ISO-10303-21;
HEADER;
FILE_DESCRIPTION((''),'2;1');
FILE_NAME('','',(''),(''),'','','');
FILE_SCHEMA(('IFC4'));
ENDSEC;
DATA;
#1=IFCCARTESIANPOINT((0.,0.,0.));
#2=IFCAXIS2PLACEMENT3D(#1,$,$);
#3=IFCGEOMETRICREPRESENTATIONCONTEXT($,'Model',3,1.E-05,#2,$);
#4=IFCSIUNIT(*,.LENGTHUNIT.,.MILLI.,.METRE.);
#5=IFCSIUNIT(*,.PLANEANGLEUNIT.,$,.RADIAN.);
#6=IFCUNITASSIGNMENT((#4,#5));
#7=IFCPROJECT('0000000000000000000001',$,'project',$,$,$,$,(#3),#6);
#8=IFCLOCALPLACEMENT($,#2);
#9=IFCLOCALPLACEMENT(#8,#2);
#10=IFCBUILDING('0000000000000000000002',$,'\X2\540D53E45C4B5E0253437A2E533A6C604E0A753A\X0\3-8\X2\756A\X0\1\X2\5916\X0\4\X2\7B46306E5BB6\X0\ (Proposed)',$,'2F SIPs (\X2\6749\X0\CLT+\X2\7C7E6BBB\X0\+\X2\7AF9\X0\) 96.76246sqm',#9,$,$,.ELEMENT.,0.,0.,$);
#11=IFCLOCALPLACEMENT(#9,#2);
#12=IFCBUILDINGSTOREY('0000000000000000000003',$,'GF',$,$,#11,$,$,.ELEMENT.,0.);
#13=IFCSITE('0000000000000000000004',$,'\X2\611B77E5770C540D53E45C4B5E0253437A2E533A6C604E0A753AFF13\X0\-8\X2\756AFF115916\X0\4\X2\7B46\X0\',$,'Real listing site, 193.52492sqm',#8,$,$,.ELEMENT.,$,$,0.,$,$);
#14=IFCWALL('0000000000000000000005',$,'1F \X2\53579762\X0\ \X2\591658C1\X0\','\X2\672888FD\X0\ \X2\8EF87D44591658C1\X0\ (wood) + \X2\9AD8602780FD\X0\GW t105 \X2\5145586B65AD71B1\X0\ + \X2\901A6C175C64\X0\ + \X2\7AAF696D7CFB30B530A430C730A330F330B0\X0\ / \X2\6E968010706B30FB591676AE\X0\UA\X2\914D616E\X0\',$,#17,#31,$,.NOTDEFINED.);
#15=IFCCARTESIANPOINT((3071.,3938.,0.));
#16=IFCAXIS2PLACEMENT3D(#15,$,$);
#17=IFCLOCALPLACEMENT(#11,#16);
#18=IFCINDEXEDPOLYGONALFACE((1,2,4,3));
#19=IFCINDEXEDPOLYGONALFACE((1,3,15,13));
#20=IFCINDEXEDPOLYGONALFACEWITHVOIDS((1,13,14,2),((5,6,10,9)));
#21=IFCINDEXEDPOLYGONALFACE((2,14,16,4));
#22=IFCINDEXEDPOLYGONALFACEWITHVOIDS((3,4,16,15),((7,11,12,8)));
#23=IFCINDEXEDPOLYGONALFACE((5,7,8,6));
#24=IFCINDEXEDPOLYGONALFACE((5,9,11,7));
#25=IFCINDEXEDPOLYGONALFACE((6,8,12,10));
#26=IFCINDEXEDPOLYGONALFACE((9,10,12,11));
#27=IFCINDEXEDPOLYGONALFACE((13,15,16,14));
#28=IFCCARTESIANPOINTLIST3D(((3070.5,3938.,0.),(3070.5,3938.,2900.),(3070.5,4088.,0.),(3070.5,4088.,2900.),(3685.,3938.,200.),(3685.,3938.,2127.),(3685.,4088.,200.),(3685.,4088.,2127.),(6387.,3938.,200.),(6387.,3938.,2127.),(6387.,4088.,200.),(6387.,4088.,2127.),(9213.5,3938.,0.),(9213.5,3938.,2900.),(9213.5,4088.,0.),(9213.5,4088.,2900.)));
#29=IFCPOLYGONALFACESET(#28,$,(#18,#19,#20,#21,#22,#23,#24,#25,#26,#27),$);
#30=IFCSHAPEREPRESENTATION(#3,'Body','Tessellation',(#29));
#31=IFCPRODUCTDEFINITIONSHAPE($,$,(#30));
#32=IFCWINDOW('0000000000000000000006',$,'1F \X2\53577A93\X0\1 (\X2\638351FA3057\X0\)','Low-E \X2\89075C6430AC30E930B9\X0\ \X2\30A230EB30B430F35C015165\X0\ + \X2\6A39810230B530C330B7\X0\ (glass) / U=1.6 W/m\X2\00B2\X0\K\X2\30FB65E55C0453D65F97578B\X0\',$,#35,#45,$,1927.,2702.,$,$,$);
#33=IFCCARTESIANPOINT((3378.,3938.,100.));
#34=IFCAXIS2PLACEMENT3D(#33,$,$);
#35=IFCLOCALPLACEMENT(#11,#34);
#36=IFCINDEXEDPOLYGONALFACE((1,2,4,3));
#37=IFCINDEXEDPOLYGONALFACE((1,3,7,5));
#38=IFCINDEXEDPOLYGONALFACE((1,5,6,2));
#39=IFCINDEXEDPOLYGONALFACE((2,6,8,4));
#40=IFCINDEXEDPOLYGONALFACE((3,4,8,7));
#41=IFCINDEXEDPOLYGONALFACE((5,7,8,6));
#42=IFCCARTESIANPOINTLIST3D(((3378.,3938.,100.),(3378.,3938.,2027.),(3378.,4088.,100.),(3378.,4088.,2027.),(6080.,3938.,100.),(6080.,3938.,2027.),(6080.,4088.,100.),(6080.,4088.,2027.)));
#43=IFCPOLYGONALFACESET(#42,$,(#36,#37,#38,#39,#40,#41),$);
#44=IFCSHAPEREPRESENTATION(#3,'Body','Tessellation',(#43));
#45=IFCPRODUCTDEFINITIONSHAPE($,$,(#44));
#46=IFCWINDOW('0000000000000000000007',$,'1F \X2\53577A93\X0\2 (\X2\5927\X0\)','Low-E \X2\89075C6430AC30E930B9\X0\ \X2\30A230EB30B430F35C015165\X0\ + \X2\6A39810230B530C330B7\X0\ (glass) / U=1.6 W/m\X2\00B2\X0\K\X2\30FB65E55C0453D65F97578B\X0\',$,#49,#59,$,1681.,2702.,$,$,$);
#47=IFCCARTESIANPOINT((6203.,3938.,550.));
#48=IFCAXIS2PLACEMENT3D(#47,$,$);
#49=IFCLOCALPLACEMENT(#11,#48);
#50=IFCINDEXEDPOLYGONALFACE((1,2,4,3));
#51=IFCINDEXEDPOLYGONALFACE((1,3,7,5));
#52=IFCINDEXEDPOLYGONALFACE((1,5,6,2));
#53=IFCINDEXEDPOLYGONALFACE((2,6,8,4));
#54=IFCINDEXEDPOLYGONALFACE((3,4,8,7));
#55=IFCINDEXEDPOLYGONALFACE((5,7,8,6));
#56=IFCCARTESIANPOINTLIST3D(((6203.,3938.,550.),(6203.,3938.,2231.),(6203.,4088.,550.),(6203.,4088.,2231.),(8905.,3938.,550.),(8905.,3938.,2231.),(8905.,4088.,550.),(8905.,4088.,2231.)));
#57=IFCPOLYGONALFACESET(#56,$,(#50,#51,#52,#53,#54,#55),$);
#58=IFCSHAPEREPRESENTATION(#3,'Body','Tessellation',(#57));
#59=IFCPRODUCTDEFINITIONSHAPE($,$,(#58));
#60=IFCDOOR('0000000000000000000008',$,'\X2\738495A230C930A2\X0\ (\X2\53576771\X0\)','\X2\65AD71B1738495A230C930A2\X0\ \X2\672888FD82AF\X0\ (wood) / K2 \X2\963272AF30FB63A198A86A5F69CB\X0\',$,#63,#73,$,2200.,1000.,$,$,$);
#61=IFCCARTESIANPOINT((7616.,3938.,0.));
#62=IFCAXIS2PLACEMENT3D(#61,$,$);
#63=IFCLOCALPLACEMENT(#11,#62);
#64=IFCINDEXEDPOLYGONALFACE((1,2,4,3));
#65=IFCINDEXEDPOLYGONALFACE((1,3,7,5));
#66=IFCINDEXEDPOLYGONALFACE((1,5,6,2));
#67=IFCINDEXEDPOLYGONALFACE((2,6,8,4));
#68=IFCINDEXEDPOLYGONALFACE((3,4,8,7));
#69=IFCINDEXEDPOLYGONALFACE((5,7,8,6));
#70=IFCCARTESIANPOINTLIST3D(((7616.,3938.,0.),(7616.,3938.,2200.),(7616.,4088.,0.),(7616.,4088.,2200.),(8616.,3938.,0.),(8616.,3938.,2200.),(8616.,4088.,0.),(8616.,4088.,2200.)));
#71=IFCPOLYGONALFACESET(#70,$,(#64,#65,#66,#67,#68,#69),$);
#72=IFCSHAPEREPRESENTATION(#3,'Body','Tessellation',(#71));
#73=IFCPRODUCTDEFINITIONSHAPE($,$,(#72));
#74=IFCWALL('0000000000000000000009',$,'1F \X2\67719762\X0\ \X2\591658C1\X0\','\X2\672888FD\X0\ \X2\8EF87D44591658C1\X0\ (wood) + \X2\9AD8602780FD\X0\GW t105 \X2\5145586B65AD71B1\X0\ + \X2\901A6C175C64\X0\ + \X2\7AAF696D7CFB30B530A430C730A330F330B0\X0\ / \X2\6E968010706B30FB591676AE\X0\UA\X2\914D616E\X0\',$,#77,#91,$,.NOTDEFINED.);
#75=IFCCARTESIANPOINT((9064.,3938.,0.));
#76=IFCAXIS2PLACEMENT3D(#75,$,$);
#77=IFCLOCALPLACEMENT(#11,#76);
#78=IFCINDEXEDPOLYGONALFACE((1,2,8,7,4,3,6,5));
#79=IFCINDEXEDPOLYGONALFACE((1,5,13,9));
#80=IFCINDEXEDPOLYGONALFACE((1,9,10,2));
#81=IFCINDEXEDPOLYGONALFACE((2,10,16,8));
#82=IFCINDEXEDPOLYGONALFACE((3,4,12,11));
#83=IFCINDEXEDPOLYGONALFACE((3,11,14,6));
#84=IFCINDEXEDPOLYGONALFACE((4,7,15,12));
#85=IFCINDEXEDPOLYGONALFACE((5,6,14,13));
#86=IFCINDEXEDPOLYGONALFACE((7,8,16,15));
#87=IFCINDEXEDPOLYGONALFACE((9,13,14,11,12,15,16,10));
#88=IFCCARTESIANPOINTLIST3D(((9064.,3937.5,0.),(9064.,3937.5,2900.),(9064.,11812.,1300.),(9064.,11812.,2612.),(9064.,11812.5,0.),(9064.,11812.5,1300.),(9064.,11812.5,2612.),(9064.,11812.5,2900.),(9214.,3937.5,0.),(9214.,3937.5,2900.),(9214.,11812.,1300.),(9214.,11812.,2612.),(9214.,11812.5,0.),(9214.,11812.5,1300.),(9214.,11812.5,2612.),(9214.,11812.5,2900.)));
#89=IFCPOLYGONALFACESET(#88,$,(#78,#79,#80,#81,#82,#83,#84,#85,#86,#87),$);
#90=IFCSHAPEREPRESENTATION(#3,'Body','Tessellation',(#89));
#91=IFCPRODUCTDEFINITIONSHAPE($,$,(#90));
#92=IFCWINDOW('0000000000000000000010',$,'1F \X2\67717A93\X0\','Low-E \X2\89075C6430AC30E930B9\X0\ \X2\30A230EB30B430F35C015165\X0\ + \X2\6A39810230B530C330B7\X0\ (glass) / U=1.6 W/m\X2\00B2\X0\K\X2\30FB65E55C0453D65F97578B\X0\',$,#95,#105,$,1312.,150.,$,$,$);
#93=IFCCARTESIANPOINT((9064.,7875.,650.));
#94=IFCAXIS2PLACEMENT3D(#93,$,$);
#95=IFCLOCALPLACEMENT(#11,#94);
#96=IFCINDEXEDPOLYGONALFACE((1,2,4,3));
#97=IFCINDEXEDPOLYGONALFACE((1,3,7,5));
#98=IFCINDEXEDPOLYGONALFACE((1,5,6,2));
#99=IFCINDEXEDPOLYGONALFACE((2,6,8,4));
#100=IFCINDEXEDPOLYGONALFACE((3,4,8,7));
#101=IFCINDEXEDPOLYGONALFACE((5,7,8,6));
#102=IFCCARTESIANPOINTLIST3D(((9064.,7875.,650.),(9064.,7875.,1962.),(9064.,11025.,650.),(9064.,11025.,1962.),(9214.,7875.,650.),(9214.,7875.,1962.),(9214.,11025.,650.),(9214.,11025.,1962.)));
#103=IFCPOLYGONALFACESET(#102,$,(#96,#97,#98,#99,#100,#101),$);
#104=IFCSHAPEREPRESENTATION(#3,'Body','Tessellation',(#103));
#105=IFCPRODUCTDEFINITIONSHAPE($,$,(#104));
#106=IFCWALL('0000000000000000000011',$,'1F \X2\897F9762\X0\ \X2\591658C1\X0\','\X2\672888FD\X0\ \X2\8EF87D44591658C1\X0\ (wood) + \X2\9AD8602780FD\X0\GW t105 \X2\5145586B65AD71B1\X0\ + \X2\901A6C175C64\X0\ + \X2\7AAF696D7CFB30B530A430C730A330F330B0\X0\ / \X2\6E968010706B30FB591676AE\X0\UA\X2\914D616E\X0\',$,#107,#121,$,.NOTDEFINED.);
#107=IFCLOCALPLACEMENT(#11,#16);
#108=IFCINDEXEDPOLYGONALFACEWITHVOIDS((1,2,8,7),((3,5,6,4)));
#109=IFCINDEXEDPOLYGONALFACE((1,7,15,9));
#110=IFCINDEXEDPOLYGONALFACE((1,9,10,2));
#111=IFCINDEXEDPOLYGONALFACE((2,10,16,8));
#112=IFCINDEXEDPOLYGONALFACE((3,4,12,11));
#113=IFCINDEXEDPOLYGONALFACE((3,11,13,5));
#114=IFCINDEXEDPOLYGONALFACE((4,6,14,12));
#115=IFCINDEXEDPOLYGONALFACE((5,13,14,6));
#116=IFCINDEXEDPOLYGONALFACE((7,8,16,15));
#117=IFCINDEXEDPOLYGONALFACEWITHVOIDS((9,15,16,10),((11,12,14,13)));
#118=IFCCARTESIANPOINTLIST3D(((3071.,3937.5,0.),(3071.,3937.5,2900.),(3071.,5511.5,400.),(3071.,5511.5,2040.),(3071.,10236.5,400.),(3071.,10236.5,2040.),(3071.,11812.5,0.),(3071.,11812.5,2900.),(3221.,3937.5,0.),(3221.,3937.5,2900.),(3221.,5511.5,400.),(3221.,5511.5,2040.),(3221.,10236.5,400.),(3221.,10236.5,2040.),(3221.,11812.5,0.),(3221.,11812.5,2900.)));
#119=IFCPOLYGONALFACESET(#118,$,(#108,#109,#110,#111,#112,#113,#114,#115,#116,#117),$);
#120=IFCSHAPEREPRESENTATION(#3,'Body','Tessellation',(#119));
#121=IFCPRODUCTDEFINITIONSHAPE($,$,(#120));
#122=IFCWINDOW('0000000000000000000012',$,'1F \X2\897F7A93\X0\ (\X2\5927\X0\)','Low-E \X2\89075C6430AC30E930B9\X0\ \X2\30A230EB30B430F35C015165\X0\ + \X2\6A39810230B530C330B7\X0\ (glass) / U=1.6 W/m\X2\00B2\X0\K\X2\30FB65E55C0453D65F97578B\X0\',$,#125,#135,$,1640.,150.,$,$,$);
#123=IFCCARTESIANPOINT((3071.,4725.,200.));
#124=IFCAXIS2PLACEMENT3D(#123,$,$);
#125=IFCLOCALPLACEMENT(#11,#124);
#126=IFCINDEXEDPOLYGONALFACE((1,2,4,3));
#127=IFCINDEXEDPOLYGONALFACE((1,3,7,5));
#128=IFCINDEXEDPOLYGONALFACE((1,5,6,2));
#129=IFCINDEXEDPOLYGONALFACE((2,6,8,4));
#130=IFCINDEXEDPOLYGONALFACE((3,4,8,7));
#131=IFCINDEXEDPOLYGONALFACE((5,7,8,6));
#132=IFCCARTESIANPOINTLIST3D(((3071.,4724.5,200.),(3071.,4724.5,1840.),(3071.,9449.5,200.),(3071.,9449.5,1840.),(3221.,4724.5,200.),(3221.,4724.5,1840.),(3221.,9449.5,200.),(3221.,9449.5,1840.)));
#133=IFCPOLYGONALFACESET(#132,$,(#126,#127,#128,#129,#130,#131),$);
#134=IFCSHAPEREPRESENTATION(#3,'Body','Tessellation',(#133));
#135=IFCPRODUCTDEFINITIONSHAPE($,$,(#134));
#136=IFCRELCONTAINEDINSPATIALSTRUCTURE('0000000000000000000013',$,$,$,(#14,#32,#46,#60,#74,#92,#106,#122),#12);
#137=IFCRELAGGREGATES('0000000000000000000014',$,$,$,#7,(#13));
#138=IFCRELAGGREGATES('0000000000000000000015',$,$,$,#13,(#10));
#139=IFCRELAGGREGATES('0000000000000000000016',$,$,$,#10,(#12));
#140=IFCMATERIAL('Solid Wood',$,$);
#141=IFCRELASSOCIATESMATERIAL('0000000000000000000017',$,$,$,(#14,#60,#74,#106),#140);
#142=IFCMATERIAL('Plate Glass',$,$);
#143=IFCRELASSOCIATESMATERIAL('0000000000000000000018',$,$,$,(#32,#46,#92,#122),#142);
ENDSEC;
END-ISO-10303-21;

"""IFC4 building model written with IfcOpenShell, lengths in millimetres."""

from ifc_helpers import new_model, si_unit, frame, frame_2d, origin, place, context, project, spatial, rectangle, extrude, material, element, fill, save


model = new_model("IFC4")

# Units and contexts
model_context = context("Model", 3, precision=1e-05, world=origin())
ifc_project = project(units=[si_unit("LENGTHUNIT", "METRE", prefix="MILLI"), si_unit("PLANEANGLEUNIT", "RADIAN")], contexts=[model_context])

# Site, building, storey
site_placement = place(None, origin())
site = spatial("IfcSite", under=ifc_project, at=site_placement, Name="愛知県名古屋市千種区池上町３-8番１外4筆", ObjectType="Real listing site, 193.52492sqm", CompositionType="ELEMENT", RefElevation=0.0)
building_placement = place(site_placement, origin())
building = spatial("IfcBuilding", under=site, at=building_placement, Name="名古屋市千種区池上町3-8番1外4筆の家 (Proposed)", ObjectType="2F SIPs (杉CLT+籾殻+竹) 96.76246sqm", CompositionType="ELEMENT", ElevationOfRefHeight=0.0, ElevationOfTerrain=0.0)
storey_placement = place(building_placement, origin())
storey = spatial("IfcBuildingStorey", under=building, at=storey_placement, Name="GF", CompositionType="ELEMENT", Elevation=0.0)

# Shared definitions
ifc_material_1 = material(Name="Solid Wood")

# Wall, openings, windows, door
wall_1_placement = place(storey_placement, frame((3071.0, 3938.0, 0.0)))
wall_1 = element("IfcWall", 1, at=wall_1_placement, inside=storey, material=ifc_material_1, Name="1F 南面 外壁", Description="木製 軸組外壁 (wood) + 高性能GW t105 充填断熱 + 通気層 + 窯業系サイディング / 準耐火・外皮UA配慮", PredefinedType="NOTDEFINED", context=model_context, shape_type="SweptSolid", body=[
    extrude(rectangle(XDim=6143.0, YDim=150.0, at=frame_2d((3071.0, 75.0))), frame((3071.0, 3938.0, 0.0)), (0.0, 0.0, 1.0), 2900.0),
])
opening_1_placement = place(storey_placement, frame((3378.0, 3938.0, 100.0)))
opening_1 = element("IfcOpeningElement", 2, at=opening_1_placement, cuts=wall_1, PredefinedType="NOTDEFINED", context=model_context, shape_type="SweptSolid", body=[
    extrude(rectangle(XDim=2702.0, YDim=150.0, at=frame_2d((1351.0, 75.0))), frame((3378.0, 3938.0, 100.0)), (0.0, 0.0, 1.0), 1927.0),
])
opening_2_placement = place(storey_placement, frame((6203.0, 3938.0, 550.0)))
opening_2 = element("IfcOpeningElement", 3, at=opening_2_placement, cuts=wall_1, PredefinedType="NOTDEFINED", context=model_context, shape_type="SweptSolid", body=[
    extrude(rectangle(XDim=2702.0, YDim=150.0, at=frame_2d((1351.0, 75.0))), frame((6203.0, 3938.0, 550.0)), (0.0, 0.0, 1.0), 1681.0),
])
opening_3_placement = place(storey_placement, frame((7616.0, 3938.0, 0.0)))
opening_3 = element("IfcOpeningElement", 4, at=opening_3_placement, cuts=wall_1, PredefinedType="NOTDEFINED", context=model_context, shape_type="SweptSolid", body=[
    extrude(rectangle(XDim=1000.0, YDim=150.0, at=frame_2d((500.0, 75.0))), frame((7616.0, 3938.0, 0.0)), (0.0, 0.0, 1.0), 2200.0),
])
ifc_material_2 = material(Name="Plate Glass")
window_1_placement = place(storey_placement, frame((3378.0, 3938.0, 100.0)))
window_1 = element("IfcWindow", 5, at=window_1_placement, inside=storey, material=ifc_material_2, Name="1F 南窓1 (掃出し)", Description="Low-E 複層ガラス アルゴン封入 + 樹脂サッシ (glass) / U=1.6 W/m²K・日射取得型", OverallHeight=1927.0, OverallWidth=2702.0, context=model_context, shape_type="SweptSolid", body=[
    extrude(rectangle(XDim=2702.0, YDim=150.0, at=frame_2d((1351.0, 75.0))), frame((3378.0, 3938.0, 100.0)), (0.0, 0.0, 1.0), 1927.0),
])
fill(opening_1, window_1)
window_2_placement = place(storey_placement, frame((6203.0, 3938.0, 550.0)))
window_2 = element("IfcWindow", 6, at=window_2_placement, inside=storey, material=ifc_material_2, Name="1F 南窓2 (大)", Description="Low-E 複層ガラス アルゴン封入 + 樹脂サッシ (glass) / U=1.6 W/m²K・日射取得型", OverallHeight=1681.0, OverallWidth=2702.0, context=model_context, shape_type="SweptSolid", body=[
    extrude(rectangle(XDim=2702.0, YDim=150.0, at=frame_2d((1351.0, 75.0))), frame((6203.0, 3938.0, 550.0)), (0.0, 0.0, 1.0), 1681.0),
])
fill(opening_2, window_2)
door_placement = place(storey_placement, frame((7616.0, 3938.0, 0.0)))
door = element("IfcDoor", 7, at=door_placement, inside=storey, material=ifc_material_1, Name="玄関ドア (南東)", Description="断熱玄関ドア 木製芯 (wood) / K2 防犯・採風機構", OverallHeight=2200.0, OverallWidth=1000.0, context=model_context, shape_type="SweptSolid", body=[
    extrude(rectangle(XDim=1000.0, YDim=150.0, at=frame_2d((500.0, 75.0))), frame((7616.0, 3938.0, 0.0)), (0.0, 0.0, 1.0), 2200.0),
])
fill(opening_3, door)

# Walls, openings, windows
wall_2_placement = place(storey_placement, frame((9064.0, 3938.0, 0.0)))
wall_2 = element("IfcWall", 8, at=wall_2_placement, inside=storey, material=ifc_material_1, Name="1F 東面 外壁", Description="木製 軸組外壁 (wood) + 高性能GW t105 充填断熱 + 通気層 + 窯業系サイディング / 準耐火・外皮UA配慮", PredefinedType="NOTDEFINED", context=model_context, shape_type="SweptSolid", body=[
    extrude(rectangle(XDim=150.0, YDim=7875.0, at=frame_2d((75.0, 3937.0))), frame((9064.0, 3938.0, 0.0)), (0.0, 0.0, 1.0), 2900.0),
])
opening_4_placement = place(storey_placement, frame((9064.0, 7875.0, 650.0)))
opening_4 = element("IfcOpeningElement", 9, at=opening_4_placement, cuts=wall_2, PredefinedType="NOTDEFINED", context=model_context, shape_type="SweptSolid", body=[
    extrude(rectangle(XDim=150.0, YDim=3150.0, at=frame_2d((75.0, 1575.0))), frame((9064.0, 7875.0, 650.0)), (0.0, 0.0, 1.0), 1312.0),
])
window_3_placement = place(storey_placement, frame((9064.0, 7875.0, 650.0)))
window_3 = element("IfcWindow", 10, at=window_3_placement, inside=storey, material=ifc_material_2, Name="1F 東窓", Description="Low-E 複層ガラス アルゴン封入 + 樹脂サッシ (glass) / U=1.6 W/m²K・日射取得型", OverallHeight=1312.0, OverallWidth=150.0, context=model_context, shape_type="SweptSolid", body=[
    extrude(rectangle(XDim=150.0, YDim=3150.0, at=frame_2d((75.0, 1575.0))), frame((9064.0, 7875.0, 650.0)), (0.0, 0.0, 1.0), 1312.0),
])
fill(opening_4, window_3)
wall_3_placement = place(storey_placement, frame((3071.0, 3938.0, 0.0)))
wall_3 = element("IfcWall", 11, at=wall_3_placement, inside=storey, material=ifc_material_1, Name="1F 西面 外壁", Description="木製 軸組外壁 (wood) + 高性能GW t105 充填断熱 + 通気層 + 窯業系サイディング / 準耐火・外皮UA配慮", PredefinedType="NOTDEFINED", context=model_context, shape_type="SweptSolid", body=[
    extrude(rectangle(XDim=150.0, YDim=7875.0, at=frame_2d((75.0, 3937.0))), frame((3071.0, 3938.0, 0.0)), (0.0, 0.0, 1.0), 2900.0),
])
opening_5_placement = place(storey_placement, frame((3071.0, 4725.0, 200.0)))
opening_5 = element("IfcOpeningElement", 12, at=opening_5_placement, cuts=wall_3, PredefinedType="NOTDEFINED", context=model_context, shape_type="SweptSolid", body=[
    extrude(rectangle(XDim=150.0, YDim=4725.0, at=frame_2d((75.0, 2362.0))), frame((3071.0, 4725.0, 200.0)), (0.0, 0.0, 1.0), 1640.0),
])
window_4_placement = place(storey_placement, frame((3071.0, 4725.0, 200.0)))
window_4 = element("IfcWindow", 13, at=window_4_placement, inside=storey, material=ifc_material_2, Name="1F 西窓 (大)", Description="Low-E 複層ガラス アルゴン封入 + 樹脂サッシ (glass) / U=1.6 W/m²K・日射取得型", OverallHeight=1640.0, OverallWidth=150.0, context=model_context, shape_type="SweptSolid", body=[
    extrude(rectangle(XDim=150.0, YDim=4725.0, at=frame_2d((75.0, 2362.0))), frame((3071.0, 4725.0, 200.0)), (0.0, 0.0, 1.0), 1640.0),
])
fill(opening_5, window_4)

save(model, "model.ifc")
